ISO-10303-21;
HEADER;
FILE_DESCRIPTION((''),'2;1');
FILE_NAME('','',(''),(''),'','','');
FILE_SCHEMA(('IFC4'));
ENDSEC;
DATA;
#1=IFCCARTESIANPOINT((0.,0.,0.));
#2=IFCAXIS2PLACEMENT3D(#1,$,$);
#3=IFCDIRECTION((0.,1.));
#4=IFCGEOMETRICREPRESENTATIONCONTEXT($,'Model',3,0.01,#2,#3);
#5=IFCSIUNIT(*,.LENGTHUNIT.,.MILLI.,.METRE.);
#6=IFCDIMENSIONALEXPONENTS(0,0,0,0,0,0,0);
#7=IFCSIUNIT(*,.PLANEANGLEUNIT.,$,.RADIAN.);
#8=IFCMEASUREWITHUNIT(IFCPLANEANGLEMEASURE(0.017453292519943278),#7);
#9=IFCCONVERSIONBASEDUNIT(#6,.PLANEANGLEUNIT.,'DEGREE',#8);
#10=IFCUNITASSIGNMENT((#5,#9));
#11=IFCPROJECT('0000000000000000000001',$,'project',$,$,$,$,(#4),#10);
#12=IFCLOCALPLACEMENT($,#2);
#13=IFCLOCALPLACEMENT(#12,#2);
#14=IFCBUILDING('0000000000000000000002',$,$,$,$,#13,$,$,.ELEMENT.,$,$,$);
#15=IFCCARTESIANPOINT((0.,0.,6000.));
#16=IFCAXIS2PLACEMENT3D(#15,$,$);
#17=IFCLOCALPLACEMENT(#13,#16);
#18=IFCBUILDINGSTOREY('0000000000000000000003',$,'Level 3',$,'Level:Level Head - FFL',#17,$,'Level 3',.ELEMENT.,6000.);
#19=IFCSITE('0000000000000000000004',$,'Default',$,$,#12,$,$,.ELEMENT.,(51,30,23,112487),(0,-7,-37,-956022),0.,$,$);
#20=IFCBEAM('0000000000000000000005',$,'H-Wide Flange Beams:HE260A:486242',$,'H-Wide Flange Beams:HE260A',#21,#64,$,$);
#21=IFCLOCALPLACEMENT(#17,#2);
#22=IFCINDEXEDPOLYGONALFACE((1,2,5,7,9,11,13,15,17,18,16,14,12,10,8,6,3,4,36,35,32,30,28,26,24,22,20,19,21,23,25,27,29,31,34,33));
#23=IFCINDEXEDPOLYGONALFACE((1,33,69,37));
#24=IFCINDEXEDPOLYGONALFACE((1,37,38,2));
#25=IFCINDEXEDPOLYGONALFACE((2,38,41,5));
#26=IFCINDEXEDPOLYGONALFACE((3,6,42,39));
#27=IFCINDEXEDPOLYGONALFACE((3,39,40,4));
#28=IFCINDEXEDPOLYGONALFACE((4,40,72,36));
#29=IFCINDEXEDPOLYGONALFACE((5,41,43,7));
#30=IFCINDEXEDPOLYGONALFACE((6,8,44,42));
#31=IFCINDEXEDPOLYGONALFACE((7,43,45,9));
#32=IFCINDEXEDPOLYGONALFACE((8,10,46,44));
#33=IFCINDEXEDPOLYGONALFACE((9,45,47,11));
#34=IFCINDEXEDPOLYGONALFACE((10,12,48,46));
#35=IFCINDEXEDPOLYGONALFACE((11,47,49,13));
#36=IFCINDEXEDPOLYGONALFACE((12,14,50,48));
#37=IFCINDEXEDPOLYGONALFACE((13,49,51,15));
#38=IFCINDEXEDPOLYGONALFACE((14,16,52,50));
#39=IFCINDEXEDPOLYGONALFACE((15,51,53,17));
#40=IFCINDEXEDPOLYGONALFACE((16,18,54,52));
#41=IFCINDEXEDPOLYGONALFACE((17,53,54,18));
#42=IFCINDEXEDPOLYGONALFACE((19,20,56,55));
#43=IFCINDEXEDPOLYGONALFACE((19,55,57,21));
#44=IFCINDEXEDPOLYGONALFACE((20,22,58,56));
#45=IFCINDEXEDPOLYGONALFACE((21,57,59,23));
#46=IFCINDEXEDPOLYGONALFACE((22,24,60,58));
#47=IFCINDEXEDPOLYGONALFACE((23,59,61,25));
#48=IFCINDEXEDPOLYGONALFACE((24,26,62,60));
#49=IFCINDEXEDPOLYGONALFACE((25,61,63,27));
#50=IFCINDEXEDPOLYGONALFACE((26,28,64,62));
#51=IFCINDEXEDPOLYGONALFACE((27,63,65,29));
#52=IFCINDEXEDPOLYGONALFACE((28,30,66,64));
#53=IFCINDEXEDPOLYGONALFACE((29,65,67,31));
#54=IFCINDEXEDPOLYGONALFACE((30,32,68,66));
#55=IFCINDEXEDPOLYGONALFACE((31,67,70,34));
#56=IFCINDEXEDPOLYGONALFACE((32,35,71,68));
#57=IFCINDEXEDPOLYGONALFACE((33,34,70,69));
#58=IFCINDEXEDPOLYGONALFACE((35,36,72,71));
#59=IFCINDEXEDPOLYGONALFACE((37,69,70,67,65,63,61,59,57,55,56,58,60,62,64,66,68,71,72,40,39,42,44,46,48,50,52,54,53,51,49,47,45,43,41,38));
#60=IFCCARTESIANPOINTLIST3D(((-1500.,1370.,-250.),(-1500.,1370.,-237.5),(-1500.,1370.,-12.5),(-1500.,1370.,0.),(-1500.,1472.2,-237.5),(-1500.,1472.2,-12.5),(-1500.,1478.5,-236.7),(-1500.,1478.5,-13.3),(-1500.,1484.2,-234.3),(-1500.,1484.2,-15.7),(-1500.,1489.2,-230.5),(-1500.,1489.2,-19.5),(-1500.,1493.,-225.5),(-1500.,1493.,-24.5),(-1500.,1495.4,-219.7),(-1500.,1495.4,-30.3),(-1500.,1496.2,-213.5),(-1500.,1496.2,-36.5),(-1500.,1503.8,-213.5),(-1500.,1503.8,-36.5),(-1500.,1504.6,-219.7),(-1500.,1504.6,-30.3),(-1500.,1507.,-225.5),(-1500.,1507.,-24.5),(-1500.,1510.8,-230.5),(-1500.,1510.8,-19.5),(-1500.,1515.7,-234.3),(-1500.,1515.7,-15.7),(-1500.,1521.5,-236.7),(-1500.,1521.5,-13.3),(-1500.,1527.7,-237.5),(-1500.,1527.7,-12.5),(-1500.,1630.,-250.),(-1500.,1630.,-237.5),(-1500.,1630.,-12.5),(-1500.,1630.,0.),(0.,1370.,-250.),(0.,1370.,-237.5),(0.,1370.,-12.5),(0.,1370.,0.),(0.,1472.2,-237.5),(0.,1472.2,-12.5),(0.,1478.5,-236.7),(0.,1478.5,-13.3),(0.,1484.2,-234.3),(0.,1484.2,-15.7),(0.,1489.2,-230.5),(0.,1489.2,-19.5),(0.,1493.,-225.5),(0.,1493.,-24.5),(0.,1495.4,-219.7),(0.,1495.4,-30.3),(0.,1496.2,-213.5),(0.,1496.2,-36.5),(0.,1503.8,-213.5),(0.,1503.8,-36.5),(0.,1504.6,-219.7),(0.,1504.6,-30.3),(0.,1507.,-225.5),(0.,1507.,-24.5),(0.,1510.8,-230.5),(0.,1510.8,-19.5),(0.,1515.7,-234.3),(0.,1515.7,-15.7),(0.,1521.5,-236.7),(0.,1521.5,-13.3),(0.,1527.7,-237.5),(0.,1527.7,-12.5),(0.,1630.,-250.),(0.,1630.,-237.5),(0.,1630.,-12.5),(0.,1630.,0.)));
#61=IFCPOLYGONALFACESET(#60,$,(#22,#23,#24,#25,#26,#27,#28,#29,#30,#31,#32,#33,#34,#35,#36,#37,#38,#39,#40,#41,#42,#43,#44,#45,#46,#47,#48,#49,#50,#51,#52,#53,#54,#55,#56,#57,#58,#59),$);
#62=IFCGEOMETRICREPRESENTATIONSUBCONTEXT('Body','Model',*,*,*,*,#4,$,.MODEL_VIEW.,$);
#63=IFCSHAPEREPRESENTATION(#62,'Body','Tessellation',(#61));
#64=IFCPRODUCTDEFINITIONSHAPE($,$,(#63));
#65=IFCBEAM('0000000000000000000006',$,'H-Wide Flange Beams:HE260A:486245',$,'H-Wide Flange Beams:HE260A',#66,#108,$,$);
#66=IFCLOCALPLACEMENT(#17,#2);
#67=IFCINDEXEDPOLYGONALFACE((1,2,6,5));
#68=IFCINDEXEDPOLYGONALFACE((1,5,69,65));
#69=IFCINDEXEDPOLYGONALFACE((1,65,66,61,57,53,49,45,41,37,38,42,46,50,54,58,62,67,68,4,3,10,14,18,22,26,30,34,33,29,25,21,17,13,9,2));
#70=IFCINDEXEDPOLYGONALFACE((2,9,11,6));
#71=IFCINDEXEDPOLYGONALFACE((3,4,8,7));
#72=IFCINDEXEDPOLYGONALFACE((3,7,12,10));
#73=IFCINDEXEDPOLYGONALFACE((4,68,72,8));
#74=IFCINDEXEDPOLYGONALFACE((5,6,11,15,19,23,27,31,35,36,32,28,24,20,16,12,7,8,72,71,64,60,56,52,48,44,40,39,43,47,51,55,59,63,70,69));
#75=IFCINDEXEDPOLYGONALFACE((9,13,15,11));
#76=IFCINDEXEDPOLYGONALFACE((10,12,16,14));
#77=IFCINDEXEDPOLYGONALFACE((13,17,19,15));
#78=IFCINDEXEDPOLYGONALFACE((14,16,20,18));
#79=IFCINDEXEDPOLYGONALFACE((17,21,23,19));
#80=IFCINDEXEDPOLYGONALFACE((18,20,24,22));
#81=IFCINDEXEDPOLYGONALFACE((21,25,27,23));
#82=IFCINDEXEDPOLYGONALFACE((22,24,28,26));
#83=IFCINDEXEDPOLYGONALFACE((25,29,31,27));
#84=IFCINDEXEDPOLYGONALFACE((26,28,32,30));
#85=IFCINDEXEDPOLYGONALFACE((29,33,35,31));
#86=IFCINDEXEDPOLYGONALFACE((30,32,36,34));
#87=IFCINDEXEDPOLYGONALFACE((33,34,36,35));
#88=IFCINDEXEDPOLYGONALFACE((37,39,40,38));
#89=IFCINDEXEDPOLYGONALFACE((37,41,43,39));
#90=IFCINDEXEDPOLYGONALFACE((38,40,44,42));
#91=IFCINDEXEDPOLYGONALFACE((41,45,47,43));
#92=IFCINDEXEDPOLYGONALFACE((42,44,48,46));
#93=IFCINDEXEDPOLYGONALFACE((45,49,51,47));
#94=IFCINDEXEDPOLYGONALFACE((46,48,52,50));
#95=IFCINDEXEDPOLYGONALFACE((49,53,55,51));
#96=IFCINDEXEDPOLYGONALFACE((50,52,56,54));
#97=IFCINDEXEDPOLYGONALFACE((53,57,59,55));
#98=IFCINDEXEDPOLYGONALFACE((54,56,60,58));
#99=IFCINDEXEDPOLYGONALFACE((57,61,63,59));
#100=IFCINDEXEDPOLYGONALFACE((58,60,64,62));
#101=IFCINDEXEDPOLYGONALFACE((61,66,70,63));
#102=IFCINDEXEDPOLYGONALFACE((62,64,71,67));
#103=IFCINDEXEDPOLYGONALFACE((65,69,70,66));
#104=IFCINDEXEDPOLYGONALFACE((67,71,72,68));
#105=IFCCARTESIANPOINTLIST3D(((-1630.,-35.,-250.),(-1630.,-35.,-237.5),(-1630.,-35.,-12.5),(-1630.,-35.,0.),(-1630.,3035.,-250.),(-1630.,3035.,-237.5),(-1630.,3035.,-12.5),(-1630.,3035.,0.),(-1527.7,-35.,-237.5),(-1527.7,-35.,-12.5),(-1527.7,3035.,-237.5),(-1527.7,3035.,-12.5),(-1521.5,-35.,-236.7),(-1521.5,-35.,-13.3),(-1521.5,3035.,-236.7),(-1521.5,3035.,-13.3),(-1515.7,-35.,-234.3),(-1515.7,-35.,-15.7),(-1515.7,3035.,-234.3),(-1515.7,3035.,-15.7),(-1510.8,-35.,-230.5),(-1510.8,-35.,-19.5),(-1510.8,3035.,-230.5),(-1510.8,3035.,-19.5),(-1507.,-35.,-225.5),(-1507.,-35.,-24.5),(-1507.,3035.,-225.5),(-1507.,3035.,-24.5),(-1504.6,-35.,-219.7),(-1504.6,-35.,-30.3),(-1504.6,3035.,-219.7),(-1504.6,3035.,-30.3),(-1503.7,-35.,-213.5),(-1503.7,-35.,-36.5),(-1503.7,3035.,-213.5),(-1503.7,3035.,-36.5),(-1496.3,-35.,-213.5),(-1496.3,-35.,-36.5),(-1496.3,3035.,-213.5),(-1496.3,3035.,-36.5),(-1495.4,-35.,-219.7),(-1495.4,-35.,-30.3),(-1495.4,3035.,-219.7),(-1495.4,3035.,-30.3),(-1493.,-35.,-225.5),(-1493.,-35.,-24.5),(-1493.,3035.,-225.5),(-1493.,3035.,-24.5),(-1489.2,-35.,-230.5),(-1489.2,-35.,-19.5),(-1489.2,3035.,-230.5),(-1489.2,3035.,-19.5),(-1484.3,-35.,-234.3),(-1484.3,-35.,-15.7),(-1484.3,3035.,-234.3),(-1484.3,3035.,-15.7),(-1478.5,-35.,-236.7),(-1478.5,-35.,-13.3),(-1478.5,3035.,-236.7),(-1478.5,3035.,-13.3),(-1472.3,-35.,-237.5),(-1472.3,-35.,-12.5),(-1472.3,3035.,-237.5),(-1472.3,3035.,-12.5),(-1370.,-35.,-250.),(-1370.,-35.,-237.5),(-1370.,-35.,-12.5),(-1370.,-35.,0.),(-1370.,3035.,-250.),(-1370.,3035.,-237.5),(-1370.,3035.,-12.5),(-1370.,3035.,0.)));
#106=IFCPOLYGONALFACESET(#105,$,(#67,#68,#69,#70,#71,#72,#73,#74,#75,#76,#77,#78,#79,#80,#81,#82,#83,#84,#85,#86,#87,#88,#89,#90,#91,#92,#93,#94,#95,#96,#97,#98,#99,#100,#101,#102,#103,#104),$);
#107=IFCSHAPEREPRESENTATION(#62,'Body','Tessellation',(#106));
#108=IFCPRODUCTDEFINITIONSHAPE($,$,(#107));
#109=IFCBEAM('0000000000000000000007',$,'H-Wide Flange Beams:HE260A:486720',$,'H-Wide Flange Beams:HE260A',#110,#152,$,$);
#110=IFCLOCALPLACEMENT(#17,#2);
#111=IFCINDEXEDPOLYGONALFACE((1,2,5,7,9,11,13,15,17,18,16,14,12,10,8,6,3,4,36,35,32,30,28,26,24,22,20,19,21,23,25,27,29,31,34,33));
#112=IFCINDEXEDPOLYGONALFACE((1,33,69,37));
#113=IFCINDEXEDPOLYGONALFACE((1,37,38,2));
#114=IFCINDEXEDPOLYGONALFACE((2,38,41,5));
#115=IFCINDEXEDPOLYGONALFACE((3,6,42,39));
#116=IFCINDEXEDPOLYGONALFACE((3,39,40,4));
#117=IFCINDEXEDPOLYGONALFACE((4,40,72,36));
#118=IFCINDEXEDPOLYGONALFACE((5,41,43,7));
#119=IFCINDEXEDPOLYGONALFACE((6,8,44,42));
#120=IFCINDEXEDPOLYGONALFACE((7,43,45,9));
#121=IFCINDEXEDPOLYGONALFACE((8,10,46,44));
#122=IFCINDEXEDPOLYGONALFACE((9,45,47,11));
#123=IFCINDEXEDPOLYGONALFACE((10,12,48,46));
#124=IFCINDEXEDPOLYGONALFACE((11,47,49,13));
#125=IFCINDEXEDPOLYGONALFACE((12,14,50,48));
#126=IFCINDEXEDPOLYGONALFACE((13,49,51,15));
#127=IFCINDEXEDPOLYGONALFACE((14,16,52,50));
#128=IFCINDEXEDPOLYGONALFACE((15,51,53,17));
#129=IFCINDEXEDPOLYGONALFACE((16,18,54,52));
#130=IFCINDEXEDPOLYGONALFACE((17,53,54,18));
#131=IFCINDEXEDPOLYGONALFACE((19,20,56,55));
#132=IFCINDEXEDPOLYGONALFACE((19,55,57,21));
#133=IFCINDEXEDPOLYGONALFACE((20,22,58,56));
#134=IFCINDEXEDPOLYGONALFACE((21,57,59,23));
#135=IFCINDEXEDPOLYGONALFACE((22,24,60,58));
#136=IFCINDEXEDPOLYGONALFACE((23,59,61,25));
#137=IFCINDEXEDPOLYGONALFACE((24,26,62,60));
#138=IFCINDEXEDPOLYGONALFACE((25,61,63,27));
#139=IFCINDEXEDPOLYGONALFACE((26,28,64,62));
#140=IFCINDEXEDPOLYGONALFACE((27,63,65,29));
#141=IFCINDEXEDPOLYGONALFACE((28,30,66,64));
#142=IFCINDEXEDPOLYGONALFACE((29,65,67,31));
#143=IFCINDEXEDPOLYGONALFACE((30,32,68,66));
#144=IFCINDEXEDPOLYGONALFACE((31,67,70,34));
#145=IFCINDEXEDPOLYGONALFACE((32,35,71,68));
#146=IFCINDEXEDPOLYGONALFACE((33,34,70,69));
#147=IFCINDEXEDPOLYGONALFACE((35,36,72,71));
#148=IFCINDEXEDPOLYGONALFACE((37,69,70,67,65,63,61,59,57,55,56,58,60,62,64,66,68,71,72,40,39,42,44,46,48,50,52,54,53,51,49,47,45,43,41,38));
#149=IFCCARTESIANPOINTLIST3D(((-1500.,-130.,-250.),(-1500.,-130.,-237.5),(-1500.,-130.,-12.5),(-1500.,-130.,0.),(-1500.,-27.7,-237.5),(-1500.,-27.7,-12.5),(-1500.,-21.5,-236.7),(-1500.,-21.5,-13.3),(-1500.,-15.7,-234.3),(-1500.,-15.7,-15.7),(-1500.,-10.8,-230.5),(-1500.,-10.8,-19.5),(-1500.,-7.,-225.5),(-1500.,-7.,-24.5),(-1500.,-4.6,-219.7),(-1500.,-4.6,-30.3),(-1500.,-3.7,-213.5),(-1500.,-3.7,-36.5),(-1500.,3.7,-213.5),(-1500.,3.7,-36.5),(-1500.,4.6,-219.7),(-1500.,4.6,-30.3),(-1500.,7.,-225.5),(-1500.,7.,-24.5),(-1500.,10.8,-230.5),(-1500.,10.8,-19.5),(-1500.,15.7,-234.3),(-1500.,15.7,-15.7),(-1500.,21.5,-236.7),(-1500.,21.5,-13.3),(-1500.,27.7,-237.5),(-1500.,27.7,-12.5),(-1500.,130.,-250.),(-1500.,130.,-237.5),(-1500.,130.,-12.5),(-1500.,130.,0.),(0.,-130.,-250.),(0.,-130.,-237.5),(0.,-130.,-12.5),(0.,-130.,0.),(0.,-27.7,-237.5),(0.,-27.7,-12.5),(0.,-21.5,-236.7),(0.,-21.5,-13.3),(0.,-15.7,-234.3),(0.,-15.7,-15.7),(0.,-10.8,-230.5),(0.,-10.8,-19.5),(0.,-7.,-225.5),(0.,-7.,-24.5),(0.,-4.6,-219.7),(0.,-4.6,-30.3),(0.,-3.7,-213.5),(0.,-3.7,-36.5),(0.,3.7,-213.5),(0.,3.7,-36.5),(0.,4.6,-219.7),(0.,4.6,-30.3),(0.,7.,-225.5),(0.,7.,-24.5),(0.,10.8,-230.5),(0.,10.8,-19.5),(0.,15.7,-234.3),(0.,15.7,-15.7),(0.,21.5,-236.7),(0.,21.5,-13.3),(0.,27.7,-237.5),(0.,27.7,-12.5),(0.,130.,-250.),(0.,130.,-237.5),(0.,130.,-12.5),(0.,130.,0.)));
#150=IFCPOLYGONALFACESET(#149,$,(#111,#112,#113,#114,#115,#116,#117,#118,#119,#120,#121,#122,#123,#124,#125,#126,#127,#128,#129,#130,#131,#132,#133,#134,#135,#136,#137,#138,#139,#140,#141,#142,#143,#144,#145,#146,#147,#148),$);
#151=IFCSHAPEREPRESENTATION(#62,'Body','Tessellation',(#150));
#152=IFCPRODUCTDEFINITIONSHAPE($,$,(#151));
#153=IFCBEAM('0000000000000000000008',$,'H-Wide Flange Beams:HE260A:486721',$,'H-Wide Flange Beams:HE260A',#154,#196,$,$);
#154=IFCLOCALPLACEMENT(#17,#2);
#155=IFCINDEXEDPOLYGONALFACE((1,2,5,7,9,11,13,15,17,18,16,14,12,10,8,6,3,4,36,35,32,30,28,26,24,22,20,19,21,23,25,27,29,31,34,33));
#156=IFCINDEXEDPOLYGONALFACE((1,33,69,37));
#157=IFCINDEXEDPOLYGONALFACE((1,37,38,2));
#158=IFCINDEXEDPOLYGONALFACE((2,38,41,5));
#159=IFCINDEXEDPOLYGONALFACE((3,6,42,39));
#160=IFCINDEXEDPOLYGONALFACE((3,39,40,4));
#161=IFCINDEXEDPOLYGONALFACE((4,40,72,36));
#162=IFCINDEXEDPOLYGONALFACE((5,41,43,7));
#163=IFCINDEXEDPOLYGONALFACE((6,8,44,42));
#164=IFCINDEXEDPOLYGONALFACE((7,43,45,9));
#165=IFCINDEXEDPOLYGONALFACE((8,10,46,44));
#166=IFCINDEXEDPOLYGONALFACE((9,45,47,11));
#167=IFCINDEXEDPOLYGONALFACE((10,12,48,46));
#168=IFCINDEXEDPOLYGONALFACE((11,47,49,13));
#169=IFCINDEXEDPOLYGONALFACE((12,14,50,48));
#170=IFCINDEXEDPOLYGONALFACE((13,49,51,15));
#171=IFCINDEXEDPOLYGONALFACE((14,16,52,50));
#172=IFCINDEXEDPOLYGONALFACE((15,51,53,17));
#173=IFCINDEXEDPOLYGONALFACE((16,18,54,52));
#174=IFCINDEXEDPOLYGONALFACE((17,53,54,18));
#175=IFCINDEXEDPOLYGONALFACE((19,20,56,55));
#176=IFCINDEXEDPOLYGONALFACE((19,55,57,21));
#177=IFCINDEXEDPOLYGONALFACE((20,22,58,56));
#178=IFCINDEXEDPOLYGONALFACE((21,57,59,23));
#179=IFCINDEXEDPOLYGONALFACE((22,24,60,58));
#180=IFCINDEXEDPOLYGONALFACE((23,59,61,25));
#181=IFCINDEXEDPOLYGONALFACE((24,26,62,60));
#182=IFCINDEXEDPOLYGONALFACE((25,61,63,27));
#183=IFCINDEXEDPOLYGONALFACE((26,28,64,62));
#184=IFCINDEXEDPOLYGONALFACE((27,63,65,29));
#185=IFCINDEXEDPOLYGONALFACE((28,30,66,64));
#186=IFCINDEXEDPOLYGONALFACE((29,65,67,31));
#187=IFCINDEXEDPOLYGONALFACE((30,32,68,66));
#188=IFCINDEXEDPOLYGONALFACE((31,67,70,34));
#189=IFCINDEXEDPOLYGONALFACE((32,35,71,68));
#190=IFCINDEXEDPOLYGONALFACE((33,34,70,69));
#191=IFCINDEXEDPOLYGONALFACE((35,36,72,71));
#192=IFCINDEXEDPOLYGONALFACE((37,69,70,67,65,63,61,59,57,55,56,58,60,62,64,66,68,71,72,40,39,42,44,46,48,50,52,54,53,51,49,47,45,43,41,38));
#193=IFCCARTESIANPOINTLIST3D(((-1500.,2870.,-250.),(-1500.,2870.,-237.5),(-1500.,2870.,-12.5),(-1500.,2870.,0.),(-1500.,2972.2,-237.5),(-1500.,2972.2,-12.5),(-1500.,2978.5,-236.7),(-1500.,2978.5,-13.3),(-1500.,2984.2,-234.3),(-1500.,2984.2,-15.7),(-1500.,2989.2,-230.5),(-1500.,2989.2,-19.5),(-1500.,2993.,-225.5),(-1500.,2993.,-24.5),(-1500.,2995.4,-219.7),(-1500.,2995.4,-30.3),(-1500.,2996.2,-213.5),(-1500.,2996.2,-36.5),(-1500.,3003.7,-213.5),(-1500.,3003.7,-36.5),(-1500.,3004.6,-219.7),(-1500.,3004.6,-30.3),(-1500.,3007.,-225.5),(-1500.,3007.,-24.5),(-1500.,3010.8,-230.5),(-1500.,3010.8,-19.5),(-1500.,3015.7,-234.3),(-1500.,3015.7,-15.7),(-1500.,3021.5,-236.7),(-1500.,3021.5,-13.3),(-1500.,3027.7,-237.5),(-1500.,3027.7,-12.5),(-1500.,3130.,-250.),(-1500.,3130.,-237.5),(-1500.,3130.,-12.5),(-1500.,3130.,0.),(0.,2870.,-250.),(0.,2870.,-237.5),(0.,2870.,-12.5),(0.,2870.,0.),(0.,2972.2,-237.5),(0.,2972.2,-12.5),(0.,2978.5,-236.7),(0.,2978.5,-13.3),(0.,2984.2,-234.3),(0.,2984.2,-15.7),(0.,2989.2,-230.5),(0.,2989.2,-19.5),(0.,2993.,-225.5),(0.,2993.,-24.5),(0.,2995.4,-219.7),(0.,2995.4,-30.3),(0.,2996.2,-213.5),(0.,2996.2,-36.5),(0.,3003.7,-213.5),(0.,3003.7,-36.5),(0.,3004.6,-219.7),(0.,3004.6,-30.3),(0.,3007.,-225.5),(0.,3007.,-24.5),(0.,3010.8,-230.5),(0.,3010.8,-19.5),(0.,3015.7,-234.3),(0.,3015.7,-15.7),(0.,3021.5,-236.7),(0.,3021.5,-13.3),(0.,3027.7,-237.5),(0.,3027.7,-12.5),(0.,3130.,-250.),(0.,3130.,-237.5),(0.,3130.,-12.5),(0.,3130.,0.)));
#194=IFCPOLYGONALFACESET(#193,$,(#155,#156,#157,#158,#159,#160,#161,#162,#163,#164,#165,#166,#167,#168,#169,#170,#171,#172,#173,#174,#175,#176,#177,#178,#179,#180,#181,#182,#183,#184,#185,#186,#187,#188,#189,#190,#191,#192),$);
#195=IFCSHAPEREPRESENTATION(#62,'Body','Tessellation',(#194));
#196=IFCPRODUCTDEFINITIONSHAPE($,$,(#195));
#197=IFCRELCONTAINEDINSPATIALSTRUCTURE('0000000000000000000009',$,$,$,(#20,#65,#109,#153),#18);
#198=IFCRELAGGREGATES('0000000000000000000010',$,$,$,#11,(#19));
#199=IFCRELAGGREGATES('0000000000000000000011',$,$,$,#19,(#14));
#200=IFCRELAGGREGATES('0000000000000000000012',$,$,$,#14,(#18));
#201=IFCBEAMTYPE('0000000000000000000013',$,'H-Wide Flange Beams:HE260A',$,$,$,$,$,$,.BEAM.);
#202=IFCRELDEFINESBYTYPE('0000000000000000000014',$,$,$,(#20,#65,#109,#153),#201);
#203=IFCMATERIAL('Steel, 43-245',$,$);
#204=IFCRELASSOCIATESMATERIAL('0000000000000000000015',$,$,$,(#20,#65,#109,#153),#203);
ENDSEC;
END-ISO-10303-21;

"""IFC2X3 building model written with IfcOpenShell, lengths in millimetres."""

from ifc_helpers import new_model, entity, si_unit, converted_unit, direction, frame, frame_2d, origin, place, context, subcontext, project, spatial, i_section, extrude, material, type_object, element, save


model = new_model("IFC2X3")

# Units and contexts
model_context = context("Model", 3, precision=0.01, world=origin(), true_north=direction((0.0, 1.0)))
body_context = subcontext(model_context, "Body", "Model", "MODEL_VIEW")
ifc_project = project(units=[si_unit("LENGTHUNIT", "METRE", prefix="MILLI"), converted_unit("PLANEANGLEUNIT", "DEGREE", entity("IfcPlaneAngleMeasure", 0.017453292519943278), si_unit("PLANEANGLEUNIT", "RADIAN"), dimensions=[0, 0, 0, 0, 0, 0, 0])], contexts=[model_context])

# Site, building, storey
site_placement = place(None, origin())
site = spatial("IfcSite", under=ifc_project, at=site_placement, Name="Default", CompositionType="ELEMENT", RefLatitude=(51, 30, 23, 112487), RefLongitude=(0, -7, -37, -956022), RefElevation=0.0)
building_placement = place(site_placement, origin())
building = spatial("IfcBuilding", under=site, at=building_placement, CompositionType="ELEMENT")
storey_placement = place(building_placement, frame((0.0, 0.0, 6000.0)))
storey = spatial("IfcBuildingStorey", under=building, at=storey_placement, Name="Level 3", ObjectType="Level:Level Head - FFL", LongName="Level 3", CompositionType="ELEMENT", Elevation=6000.0)

# Beams
ifc_material = material(Name="Steel, 43-245")
beam_type_1 = type_object("IfcBeamType", Name="H-Wide Flange Beams:HE260A", PredefinedType="BEAM")
beam_1_placement = place(storey_placement, frame((0.0, 1500.0, 0.0), z_axis=(0.0, 0.0, 1.0), x_axis=(-1.0, 0.0, 0.0)))
element("IfcBeam", 1, at=beam_1_placement, inside=storey, type_object=beam_type_1, material=ifc_material, Name="H-Wide Flange Beams:HE260A:486242", ObjectType="H-Wide Flange Beams:HE260A", context=body_context, shape_type="SweptSolid", body=[
    extrude(i_section(OverallWidth=260.0, OverallDepth=250.0, WebThickness=7.5, FlangeThickness=12.5, FilletRadius=24.0, at=frame_2d((0.0, 0.0), x_axis=(0.0, 1.0))), frame((0.0, 0.0, -125.0), z_axis=(1.0, 0.0, 0.0), x_axis=(0.0, 0.0, -1.0)), (0.0, 0.0, 1.0), 1500.0),
])
beam_2_placement = place(storey_placement, frame((-1500.0, 0.0, 0.0), z_axis=(0.0, 0.0, 1.0), x_axis=(0.0, 1.0, 0.0)))
element("IfcBeam", 2, at=beam_2_placement, inside=storey, type_object=beam_type_1, material=ifc_material, Name="H-Wide Flange Beams:HE260A:486245", ObjectType="H-Wide Flange Beams:HE260A", context=body_context, shape_type="SweptSolid", body=[
    extrude(i_section(OverallWidth=260.0, OverallDepth=250.0, WebThickness=7.5, FlangeThickness=12.5, FilletRadius=24.0, at=frame_2d((0.0, 0.0), x_axis=(0.0, 1.0))), frame((-35.0, 0.0, -125.0), z_axis=(1.0, 0.0, 0.0), x_axis=(0.0, 0.0, -1.0)), (0.0, 0.0, 1.0), 3070.0),
])
beam_3_placement = place(storey_placement, frame((-1500.0, 0.0, 0.0)))
element("IfcBeam", 3, at=beam_3_placement, inside=storey, type_object=beam_type_1, material=ifc_material, Name="H-Wide Flange Beams:HE260A:486720", ObjectType="H-Wide Flange Beams:HE260A", context=body_context, shape_type="SweptSolid", body=[
    extrude(i_section(OverallWidth=260.0, OverallDepth=250.0, WebThickness=7.5, FlangeThickness=12.5, FilletRadius=24.0, at=frame_2d((0.0, 0.0), x_axis=(0.0, 1.0))), frame((0.0, 0.0, -125.0), z_axis=(1.0, 0.0, 0.0), x_axis=(0.0, 0.0, -1.0)), (0.0, 0.0, 1.0), 1500.0),
])
beam_4_placement = place(storey_placement, frame((0.0, 3000.0, 0.0), z_axis=(0.0, 0.0, 1.0), x_axis=(-1.0, 0.0, 0.0)))
element("IfcBeam", 4, at=beam_4_placement, inside=storey, type_object=beam_type_1, material=ifc_material, Name="H-Wide Flange Beams:HE260A:486721", ObjectType="H-Wide Flange Beams:HE260A", context=body_context, shape_type="SweptSolid", body=[
    extrude(i_section(OverallWidth=260.0, OverallDepth=250.0, WebThickness=7.5, FlangeThickness=12.5, FilletRadius=24.0, at=frame_2d((0.0, 0.0), x_axis=(0.0, 1.0))), frame((0.0, 0.0, -125.0), z_axis=(1.0, 0.0, 0.0), x_axis=(0.0, 0.0, -1.0)), (0.0, 0.0, 1.0), 1500.0),
])

save(model, "model.ifc")
